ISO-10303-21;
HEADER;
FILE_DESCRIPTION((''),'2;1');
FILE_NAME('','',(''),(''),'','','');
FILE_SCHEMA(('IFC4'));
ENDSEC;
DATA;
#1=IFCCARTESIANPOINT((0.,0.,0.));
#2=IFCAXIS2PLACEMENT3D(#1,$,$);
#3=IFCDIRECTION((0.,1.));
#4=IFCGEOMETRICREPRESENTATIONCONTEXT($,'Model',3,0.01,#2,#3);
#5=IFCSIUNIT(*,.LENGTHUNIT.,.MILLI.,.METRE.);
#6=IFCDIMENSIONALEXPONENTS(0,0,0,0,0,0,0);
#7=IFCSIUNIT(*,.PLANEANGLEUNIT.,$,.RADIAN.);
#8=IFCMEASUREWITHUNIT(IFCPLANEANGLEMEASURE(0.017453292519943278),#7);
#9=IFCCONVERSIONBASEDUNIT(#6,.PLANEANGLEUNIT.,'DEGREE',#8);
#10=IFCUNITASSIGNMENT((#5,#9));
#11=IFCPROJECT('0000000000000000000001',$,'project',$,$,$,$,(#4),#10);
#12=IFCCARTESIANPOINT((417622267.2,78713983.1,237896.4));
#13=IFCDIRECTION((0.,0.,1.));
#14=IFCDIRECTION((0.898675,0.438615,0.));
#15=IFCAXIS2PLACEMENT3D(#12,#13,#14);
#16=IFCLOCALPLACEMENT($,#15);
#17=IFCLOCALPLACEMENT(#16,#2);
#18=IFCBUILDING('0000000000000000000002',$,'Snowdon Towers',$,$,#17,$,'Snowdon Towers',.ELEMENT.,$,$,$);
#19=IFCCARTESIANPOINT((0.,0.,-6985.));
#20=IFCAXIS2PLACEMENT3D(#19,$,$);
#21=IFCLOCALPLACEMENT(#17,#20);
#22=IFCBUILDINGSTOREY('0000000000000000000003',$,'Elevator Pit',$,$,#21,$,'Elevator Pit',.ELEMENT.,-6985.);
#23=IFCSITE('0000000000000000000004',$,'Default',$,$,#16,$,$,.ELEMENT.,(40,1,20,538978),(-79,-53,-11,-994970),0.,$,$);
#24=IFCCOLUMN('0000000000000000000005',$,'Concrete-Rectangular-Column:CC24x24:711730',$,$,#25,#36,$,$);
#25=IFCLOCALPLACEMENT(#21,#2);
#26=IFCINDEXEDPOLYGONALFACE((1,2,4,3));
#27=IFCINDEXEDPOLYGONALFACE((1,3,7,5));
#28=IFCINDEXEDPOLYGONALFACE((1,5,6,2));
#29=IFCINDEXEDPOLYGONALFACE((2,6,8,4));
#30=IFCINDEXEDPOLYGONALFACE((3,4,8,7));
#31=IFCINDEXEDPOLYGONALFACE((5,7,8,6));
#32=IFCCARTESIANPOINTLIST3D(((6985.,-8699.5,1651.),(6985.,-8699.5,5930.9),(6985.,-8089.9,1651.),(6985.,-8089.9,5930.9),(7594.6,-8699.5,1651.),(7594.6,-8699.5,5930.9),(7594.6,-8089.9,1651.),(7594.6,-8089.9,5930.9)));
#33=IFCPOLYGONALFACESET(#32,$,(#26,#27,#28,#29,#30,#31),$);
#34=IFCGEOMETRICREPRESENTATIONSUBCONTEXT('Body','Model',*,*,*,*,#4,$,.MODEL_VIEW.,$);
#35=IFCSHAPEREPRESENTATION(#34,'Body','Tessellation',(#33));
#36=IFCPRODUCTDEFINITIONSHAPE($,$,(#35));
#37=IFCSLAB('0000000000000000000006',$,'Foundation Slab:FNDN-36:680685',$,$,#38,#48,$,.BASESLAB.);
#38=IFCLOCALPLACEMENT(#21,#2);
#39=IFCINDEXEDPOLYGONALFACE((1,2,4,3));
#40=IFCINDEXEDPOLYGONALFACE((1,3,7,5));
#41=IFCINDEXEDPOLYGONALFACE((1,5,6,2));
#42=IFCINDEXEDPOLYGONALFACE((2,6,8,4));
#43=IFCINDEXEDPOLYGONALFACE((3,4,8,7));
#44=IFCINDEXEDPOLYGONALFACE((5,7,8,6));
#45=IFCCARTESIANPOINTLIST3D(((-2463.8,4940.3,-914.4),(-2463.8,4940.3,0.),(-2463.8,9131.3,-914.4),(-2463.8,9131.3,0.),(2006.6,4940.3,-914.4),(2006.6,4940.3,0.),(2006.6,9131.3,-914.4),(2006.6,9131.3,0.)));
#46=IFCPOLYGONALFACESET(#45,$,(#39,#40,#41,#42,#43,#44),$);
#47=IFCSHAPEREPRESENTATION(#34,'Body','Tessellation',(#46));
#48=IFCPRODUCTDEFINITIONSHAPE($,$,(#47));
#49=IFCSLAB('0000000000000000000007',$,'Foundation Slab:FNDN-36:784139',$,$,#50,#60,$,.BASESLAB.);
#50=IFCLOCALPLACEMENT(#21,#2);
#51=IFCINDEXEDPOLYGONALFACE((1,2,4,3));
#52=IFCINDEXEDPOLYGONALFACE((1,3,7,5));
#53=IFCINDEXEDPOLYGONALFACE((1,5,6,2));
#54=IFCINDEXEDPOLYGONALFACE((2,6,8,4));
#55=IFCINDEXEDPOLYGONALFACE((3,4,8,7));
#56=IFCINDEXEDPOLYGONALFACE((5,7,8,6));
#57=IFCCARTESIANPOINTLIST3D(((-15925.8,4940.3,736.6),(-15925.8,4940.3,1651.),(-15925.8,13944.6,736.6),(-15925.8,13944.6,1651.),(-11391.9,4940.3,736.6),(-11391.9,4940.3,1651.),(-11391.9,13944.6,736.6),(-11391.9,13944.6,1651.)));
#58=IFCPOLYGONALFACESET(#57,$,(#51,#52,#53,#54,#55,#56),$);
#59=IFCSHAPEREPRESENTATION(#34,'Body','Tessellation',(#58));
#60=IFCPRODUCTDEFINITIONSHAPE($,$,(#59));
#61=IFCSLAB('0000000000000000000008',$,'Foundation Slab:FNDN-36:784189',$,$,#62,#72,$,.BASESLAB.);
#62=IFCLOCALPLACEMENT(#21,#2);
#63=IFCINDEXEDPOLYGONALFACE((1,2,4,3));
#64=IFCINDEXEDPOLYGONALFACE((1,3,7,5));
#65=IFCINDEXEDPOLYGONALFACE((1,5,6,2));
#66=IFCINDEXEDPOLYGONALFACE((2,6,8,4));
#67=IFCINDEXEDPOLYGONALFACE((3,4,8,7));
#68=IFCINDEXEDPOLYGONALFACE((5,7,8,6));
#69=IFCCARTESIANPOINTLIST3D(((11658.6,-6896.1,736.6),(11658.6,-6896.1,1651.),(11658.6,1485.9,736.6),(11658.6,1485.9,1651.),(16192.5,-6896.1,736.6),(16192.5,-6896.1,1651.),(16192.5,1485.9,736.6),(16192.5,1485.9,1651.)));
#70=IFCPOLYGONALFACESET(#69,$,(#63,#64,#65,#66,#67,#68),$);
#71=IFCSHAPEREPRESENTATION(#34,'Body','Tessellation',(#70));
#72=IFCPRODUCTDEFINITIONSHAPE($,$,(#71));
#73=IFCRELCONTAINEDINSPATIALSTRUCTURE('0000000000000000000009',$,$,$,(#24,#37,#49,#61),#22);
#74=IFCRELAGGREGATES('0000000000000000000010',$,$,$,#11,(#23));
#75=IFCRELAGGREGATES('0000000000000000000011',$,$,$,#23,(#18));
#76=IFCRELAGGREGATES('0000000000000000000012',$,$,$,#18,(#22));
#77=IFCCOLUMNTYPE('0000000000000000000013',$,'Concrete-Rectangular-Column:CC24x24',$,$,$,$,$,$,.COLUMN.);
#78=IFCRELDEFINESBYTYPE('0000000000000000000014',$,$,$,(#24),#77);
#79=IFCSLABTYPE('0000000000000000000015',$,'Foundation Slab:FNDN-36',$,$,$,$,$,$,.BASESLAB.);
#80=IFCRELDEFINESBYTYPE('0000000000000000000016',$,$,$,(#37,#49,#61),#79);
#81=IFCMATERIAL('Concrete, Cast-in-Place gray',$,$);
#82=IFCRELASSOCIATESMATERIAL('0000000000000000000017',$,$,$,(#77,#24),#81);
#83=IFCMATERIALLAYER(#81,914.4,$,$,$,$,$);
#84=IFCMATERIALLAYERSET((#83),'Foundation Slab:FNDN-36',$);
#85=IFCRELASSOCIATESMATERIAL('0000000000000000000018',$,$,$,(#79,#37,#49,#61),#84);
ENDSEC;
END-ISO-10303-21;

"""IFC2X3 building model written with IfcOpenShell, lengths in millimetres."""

from ifc_helpers import new_model, entity, si_unit, converted_unit, direction, frame, frame_2d, origin, origin_2d_with_axis, place, context, subcontext, project, spatial, rectangle, extrude, source, transform, mapped, material, layer, layer_set, layer_usage, type_object, type_shapes, element, save


model = new_model("IFC2X3")

# Units and contexts
model_context = context("Model", 3, precision=0.01, world=origin(), true_north=direction((0.0, 1.0)))
body_context = subcontext(model_context, "Body", "Model", "MODEL_VIEW")
ifc_project = project(units=[si_unit("LENGTHUNIT", "METRE", prefix="MILLI"), converted_unit("PLANEANGLEUNIT", "DEGREE", entity("IfcPlaneAngleMeasure", 0.017453292519943278), si_unit("PLANEANGLEUNIT", "RADIAN"), dimensions=[0, 0, 0, 0, 0, 0, 0])], contexts=[model_context])

# Site, building, storey
site_placement = place(None, frame((417622267.2, 78713983.1, 237896.4), z_axis=(0.0, 0.0, 1.0), x_axis=(0.898675, 0.438615, 0.0)))
site = spatial("IfcSite", under=ifc_project, at=site_placement, Name="Default", CompositionType="ELEMENT", RefLatitude=(40, 1, 20, 538978), RefLongitude=(-79, -53, -11, -994970), RefElevation=0.0)
building_placement = place(site_placement, origin())
building = spatial("IfcBuilding", under=site, at=building_placement, Name="Snowdon Towers", LongName="Snowdon Towers", CompositionType="ELEMENT")
storey_placement = place(building_placement, frame((0.0, 0.0, -6985.0)))
storey = spatial("IfcBuildingStorey", under=building, at=storey_placement, Name="Elevator Pit", LongName="Elevator Pit", CompositionType="ELEMENT", Elevation=-6985.0)

# Shared definitions
ifc_material = material(Name="Concrete, Cast-in-Place gray")

# Column
column_type_1 = type_object("IfcColumnType", Name="Concrete-Rectangular-Column:CC24x24", PredefinedType="COLUMN", material=ifc_material)
shared_shape_1 = source(origin(), body_context, "Body", "SweptSolid", [
    extrude(rectangle(XDim=609.6, YDim=609.6, at=origin_2d_with_axis()), frame((7289.8, -8394.7, -5334.0), z_axis=(0.0, 0.0, 1.0), x_axis=(-1.0, 0.0, 0.0)), (0.0, 0.0, 1.0), 4279.9),
])
type_shapes(column_type_1, [shared_shape_1])
column_1_placement = place(storey_placement, frame((0.0, 0.0, 6985.0)))
element("IfcColumn", 1, at=column_1_placement, inside=storey, type_object=column_type_1, material=ifc_material, Name="Concrete-Rectangular-Column:CC24x24:711730", context=body_context, shape_type="MappedRepresentation", body=[
    mapped(shared_shape_1, transform((0.0, 0.0, 0.0), scale=1.0)),
])

# Slabs
ifc_layer = layer(ifc_material, 914.4)
ifc_layer_set = layer_set([ifc_layer], Name="Foundation Slab:FNDN-36")
ifc_layer_usage_1 = layer_usage(ifc_layer_set, "AXIS3", "POSITIVE", 0.0)
slab_type_1 = type_object("IfcSlabType", Name="Foundation Slab:FNDN-36", PredefinedType="BASESLAB", material=ifc_layer_set)
slab_1_placement = place(storey_placement, origin())
element("IfcSlab", 2, at=slab_1_placement, inside=storey, type_object=slab_type_1, material=ifc_layer_usage_1, Name="Foundation Slab:FNDN-36:680685", PredefinedType="BASESLAB", context=body_context, shape_type="SweptSolid", body=[
    extrude(rectangle(XDim=4191.0, YDim=4470.4, at=frame_2d((0.0, 0.0), x_axis=(1.0, 0.0))), frame((-228.6, 7035.8, 0.0), z_axis=(0.0, 0.0, -1.0), x_axis=(0.0, 1.0, 0.0)), (0.0, 0.0, 1.0), 914.4),
])
ifc_layer_usage_2 = layer_usage(ifc_layer_set, "AXIS3", "POSITIVE", 0.0)
slab_2_placement = place(storey_placement, origin())
element("IfcSlab", 3, at=slab_2_placement, inside=storey, type_object=slab_type_1, material=ifc_layer_usage_2, Name="Foundation Slab:FNDN-36:784139", PredefinedType="BASESLAB", context=body_context, shape_type="SweptSolid", body=[
    extrude(rectangle(XDim=9004.3, YDim=4533.9, at=frame_2d((0.0, 0.0), x_axis=(1.0, 0.0))), frame((-13658.8, 9442.5, 1651.0), z_axis=(0.0, 0.0, -1.0), x_axis=(0.0, 1.0, 0.0)), (0.0, 0.0, 1.0), 914.4),
])
ifc_layer_usage_3 = layer_usage(ifc_layer_set, "AXIS3", "POSITIVE", 0.0)
slab_3_placement = place(storey_placement, origin())
element("IfcSlab", 4, at=slab_3_placement, inside=storey, type_object=slab_type_1, material=ifc_layer_usage_3, Name="Foundation Slab:FNDN-36:784189", PredefinedType="BASESLAB", context=body_context, shape_type="SweptSolid", body=[
    extrude(rectangle(XDim=8382.0, YDim=4533.9, at=frame_2d((0.0, 0.0), x_axis=(1.0, 0.0))), frame((13925.6, -2705.1, 1651.0), z_axis=(0.0, 0.0, -1.0), x_axis=(0.0, 1.0, 0.0)), (0.0, 0.0, 1.0), 914.4),
])

save(model, "model.ifc")
